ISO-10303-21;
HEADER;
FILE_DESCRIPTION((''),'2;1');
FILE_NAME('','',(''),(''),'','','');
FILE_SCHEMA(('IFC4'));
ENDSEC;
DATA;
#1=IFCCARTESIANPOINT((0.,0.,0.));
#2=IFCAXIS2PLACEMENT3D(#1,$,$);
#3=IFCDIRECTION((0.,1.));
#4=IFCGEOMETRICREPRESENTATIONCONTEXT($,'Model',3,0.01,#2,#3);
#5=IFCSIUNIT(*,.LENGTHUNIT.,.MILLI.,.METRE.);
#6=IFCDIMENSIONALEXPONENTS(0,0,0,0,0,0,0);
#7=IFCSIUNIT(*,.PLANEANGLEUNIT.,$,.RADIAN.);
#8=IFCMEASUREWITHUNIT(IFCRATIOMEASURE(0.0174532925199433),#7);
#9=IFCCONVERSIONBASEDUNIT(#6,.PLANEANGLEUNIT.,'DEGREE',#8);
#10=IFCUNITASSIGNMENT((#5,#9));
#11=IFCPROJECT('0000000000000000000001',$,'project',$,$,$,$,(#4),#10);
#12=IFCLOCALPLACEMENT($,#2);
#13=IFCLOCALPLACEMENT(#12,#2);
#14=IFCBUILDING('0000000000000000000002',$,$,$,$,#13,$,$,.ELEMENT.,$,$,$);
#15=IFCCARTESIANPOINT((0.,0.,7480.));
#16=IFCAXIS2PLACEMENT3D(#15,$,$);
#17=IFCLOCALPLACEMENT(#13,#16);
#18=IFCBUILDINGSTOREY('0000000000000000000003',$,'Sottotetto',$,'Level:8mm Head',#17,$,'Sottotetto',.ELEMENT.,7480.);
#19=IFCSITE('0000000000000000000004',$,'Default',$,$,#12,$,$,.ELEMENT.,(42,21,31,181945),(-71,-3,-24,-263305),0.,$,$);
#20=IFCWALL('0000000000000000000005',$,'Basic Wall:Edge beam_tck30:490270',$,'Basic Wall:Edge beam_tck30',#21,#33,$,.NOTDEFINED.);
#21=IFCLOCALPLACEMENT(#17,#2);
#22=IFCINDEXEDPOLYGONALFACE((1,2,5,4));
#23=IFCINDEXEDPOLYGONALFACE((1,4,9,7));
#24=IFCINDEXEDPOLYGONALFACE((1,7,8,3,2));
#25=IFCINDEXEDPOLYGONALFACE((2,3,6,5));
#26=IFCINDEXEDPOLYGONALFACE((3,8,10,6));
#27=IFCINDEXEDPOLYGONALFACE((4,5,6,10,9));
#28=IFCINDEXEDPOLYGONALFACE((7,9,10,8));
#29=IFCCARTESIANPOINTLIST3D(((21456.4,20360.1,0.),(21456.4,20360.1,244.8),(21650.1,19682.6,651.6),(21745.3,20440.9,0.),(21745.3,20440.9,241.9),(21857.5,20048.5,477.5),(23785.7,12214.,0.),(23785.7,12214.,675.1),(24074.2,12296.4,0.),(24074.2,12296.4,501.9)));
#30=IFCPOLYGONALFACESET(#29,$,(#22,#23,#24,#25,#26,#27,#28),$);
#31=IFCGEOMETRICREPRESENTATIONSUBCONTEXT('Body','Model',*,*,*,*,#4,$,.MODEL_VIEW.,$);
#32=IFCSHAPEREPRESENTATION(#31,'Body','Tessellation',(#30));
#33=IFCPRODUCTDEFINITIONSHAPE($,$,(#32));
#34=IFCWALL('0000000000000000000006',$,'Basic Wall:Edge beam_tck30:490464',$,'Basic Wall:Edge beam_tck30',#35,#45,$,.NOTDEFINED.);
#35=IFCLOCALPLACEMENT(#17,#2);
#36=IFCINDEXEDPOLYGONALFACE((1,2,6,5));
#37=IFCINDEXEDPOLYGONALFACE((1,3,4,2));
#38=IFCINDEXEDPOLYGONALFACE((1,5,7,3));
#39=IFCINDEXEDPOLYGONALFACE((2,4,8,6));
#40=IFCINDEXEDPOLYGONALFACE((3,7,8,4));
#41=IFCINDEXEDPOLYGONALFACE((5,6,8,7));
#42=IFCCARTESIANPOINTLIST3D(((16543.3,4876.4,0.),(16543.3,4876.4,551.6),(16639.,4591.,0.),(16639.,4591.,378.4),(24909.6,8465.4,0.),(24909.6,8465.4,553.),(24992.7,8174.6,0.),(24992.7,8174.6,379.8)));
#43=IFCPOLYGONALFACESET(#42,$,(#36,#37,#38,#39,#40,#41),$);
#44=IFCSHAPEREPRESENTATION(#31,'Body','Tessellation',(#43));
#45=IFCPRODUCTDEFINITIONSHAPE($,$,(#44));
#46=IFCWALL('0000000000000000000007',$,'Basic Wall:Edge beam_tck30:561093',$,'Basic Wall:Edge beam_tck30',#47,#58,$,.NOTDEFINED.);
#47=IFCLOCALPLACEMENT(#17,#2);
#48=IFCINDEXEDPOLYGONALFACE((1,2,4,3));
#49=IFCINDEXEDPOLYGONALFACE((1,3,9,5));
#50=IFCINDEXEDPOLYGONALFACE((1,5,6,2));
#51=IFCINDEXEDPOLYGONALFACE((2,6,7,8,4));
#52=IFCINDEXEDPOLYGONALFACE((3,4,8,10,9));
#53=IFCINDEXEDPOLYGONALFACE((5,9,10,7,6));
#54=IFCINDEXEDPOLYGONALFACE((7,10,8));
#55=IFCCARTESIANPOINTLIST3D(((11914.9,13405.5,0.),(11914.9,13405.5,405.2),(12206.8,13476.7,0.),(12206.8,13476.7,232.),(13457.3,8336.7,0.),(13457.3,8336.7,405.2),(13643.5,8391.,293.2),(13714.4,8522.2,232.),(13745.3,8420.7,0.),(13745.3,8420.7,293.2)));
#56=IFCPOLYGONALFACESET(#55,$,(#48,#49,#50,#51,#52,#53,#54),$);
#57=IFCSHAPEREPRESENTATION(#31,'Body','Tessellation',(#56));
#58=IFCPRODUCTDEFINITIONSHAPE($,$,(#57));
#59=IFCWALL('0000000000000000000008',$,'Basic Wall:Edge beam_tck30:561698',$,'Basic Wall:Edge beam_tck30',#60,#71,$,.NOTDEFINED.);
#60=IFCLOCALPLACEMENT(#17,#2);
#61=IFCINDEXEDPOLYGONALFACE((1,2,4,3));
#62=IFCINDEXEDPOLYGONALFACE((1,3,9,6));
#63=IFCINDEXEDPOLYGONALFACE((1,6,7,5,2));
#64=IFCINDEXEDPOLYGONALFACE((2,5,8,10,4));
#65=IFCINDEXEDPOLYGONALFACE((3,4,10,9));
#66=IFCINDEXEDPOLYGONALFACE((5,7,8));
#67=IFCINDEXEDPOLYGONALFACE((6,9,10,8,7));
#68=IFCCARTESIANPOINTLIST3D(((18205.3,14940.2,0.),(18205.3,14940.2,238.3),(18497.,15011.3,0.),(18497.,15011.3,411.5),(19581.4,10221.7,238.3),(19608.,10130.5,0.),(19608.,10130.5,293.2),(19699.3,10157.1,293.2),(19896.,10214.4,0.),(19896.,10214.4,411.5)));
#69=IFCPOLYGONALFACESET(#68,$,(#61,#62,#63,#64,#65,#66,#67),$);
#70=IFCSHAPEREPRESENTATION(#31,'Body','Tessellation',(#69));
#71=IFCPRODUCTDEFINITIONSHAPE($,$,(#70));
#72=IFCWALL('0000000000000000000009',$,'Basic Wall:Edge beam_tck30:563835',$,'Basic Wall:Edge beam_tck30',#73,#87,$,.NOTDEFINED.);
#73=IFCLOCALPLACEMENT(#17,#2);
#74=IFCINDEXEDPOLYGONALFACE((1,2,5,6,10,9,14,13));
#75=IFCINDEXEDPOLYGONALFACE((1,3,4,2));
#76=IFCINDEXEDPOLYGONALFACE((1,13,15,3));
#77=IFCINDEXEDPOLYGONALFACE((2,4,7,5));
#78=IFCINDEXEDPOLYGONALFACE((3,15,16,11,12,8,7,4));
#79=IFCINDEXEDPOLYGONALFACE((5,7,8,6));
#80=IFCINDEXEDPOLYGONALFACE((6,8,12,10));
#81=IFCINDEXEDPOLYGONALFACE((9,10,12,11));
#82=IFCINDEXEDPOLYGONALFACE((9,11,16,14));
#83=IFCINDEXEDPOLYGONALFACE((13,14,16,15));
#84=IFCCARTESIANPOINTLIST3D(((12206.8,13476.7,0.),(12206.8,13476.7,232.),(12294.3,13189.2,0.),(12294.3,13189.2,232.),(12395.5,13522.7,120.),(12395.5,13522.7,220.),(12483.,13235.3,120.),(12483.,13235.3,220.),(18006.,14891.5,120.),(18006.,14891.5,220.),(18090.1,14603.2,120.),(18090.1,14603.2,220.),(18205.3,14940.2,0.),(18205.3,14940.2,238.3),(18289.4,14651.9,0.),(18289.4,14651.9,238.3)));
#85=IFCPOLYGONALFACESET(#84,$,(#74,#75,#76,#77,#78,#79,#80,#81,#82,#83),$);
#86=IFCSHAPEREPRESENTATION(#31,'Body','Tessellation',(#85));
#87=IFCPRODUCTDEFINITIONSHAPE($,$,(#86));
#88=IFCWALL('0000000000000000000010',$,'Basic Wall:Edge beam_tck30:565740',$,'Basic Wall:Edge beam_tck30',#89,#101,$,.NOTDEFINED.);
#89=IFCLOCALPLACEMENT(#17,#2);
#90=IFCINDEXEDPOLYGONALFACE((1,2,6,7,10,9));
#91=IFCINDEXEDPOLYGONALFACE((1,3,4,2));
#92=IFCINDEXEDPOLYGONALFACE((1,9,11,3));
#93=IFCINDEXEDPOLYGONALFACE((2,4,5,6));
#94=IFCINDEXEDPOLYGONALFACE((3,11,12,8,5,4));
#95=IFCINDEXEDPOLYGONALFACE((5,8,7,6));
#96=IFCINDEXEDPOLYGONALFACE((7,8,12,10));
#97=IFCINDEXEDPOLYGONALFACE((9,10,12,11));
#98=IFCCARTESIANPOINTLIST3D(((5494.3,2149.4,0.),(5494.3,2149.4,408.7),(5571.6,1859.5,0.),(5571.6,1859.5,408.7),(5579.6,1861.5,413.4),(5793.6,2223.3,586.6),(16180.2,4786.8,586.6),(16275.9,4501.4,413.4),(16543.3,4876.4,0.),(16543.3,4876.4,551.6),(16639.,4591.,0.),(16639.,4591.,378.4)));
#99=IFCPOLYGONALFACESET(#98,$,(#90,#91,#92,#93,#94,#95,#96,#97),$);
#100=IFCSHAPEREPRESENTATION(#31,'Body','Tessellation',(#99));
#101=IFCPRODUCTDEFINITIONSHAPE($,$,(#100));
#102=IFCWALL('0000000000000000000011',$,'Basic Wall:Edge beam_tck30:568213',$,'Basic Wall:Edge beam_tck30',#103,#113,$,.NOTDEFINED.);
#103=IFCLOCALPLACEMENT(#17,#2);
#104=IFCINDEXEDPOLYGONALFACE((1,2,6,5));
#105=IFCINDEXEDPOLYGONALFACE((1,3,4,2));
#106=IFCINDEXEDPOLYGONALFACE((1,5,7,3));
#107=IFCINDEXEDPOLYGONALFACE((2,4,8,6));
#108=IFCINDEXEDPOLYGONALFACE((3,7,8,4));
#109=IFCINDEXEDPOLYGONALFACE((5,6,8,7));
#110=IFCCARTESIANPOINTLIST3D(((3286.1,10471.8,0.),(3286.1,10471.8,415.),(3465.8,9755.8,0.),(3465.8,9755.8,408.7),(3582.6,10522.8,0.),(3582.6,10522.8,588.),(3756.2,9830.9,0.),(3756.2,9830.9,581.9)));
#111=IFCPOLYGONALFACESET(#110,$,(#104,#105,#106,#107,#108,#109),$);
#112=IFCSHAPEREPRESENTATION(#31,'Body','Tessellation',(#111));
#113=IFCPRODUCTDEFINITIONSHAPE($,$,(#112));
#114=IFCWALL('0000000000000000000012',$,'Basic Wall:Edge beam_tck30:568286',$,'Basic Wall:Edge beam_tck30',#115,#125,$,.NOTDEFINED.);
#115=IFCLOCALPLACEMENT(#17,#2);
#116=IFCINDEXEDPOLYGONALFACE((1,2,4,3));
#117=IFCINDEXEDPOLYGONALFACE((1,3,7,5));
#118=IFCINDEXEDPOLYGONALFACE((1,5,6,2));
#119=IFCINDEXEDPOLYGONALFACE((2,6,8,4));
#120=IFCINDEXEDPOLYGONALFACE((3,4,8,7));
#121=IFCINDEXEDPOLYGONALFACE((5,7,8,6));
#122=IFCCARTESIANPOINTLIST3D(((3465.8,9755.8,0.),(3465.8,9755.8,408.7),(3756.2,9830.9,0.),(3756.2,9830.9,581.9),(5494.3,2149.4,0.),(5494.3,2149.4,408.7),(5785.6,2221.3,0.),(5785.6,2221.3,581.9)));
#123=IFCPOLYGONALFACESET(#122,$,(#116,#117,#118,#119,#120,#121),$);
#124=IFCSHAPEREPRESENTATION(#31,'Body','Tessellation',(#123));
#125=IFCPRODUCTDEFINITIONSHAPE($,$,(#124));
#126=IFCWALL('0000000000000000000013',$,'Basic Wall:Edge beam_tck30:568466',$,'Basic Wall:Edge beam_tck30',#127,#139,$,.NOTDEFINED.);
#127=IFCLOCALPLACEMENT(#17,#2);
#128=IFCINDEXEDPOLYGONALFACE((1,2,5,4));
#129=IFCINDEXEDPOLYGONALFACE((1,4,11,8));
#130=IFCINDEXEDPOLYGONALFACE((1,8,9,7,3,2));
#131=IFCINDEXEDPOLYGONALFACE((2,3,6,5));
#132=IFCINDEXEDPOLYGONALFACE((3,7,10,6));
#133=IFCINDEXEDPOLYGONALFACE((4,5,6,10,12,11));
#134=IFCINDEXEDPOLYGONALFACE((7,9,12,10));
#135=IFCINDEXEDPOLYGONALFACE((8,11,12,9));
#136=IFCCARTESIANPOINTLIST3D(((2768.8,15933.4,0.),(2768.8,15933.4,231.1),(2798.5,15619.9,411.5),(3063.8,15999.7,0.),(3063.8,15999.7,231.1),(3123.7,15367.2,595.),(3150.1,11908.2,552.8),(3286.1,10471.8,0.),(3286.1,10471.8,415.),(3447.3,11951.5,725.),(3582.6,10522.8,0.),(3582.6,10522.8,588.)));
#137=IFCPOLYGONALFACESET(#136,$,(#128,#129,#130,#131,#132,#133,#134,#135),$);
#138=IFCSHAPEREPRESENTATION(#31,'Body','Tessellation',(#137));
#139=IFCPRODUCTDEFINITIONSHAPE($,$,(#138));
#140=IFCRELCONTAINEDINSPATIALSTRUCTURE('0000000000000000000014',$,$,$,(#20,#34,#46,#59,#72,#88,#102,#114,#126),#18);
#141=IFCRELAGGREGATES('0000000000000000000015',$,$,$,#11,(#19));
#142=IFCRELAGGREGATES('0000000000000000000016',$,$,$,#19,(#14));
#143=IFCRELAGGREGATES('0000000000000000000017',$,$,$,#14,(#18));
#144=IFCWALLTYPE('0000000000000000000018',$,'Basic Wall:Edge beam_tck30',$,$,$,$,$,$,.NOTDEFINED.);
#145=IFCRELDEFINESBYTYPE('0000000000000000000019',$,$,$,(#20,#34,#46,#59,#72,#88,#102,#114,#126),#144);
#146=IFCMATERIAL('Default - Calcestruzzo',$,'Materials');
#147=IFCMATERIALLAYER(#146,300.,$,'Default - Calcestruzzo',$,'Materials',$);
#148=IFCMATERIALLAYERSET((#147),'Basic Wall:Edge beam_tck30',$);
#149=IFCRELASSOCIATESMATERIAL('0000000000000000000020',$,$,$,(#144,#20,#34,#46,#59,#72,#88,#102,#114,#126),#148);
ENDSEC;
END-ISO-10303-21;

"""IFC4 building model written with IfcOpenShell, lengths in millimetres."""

from ifc_helpers import new_model, entity, si_unit, converted_unit, direction, frame, origin, place, context, subcontext, project, spatial, polyline, outline, extrude, clip, bounded_halfspace, material, layer, layer_set, layer_usage, type_object, element, save


model = new_model("IFC4")

# Units and contexts
model_context = context("Model", 3, precision=0.01, world=origin(), true_north=direction((0.0, 1.0)))
body_context = subcontext(model_context, "Body", "Model", "MODEL_VIEW")
ifc_project = project(units=[si_unit("LENGTHUNIT", "METRE", prefix="MILLI"), converted_unit("PLANEANGLEUNIT", "DEGREE", entity("IfcRatioMeasure", 0.0174532925199433), si_unit("PLANEANGLEUNIT", "RADIAN"), dimensions=[0, 0, 0, 0, 0, 0, 0])], contexts=[model_context])

# Site, building, storey
site_placement = place(None, origin())
site = spatial("IfcSite", under=ifc_project, at=site_placement, Name="Default", CompositionType="ELEMENT", RefLatitude=(42, 21, 31, 181945), RefLongitude=(-71, -3, -24, -263305), RefElevation=0.0)
building_placement = place(site_placement, origin())
building = spatial("IfcBuilding", under=site, at=building_placement, CompositionType="ELEMENT")
storey_placement = place(building_placement, frame((0.0, 0.0, 7480.0)))
storey = spatial("IfcBuildingStorey", under=building, at=storey_placement, Name="Sottotetto", ObjectType="Level:8mm Head", LongName="Sottotetto", CompositionType="ELEMENT", Elevation=7480.0)

# Walls
ifc_material_1 = material(Name="Default - Calcestruzzo", Category="Materials")
ifc_layer_1 = layer(ifc_material_1, 300.0, Name="Default - Calcestruzzo", Category="Materials")
ifc_layer_set_1 = layer_set([ifc_layer_1], Name="Basic Wall:Edge beam_tck30")
ifc_layer_usage_1 = layer_usage(ifc_layer_set_1, "AXIS2", "NEGATIVE", 150.0)
wall_type = type_object("IfcWallType", Name="Basic Wall:Edge beam_tck30", PredefinedType="NOTDEFINED", material=ifc_layer_set_1)
wall_1_placement = place(storey_placement, frame((21600.6, 20401.4, 0.0), z_axis=(0.0, 0.0, 1.0), x_axis=(0.274927, -0.961465, 0.0)))
element("IfcWall", 1, at=wall_1_placement, inside=storey, type_object=wall_type, material=ifc_layer_usage_1, Name="Basic Wall:Edge beam_tck30:490270", ObjectType="Basic Wall:Edge beam_tck30", PredefinedType="NOTDEFINED", context=body_context, shape_type="Clipping", body=[
    clip(clip(extrude(outline(polyline([(8472.6, -150.0), (8472.6, -100.1), (8472.6, 150.0), (1.8, 150.0), (0.0, -150.0), (300.0, -150.0), (8472.6, -150.0)])), origin(), (0.0, 0.0, 1.0), 675.1), bounded_halfspace(frame((0.0, -150.0, 244.8), z_axis=(-0.499867, 0.011539, 0.866025), x_axis=(-0.023077, -0.999734, 0.0)), False, frame((0.0, -150.0, 244.8)), polyline([(0.0, 0.0), (704.6, 0.0), (409.9, 300.0), (1.8, 300.0), (0.0, 0.0)]))), bounded_halfspace(frame((704.6, -150.0, 651.6), z_axis=(-0.002627, 0.499993, 0.866025), x_axis=(-0.999986, -0.005253, 0.0)), False, frame((704.6, -150.0, 651.6)), polyline([(0.0, 0.0), (7768.0, 0.0), (7768.0, 49.9), (7768.0, 300.0), (-294.7, 300.0), (0.0, 0.0)]))),
])
ifc_layer_usage_2 = layer_usage(ifc_layer_set_1, "AXIS2", "NEGATIVE", 150.0)
wall_2_placement = place(storey_placement, frame((24968.7, 8327.5, 0.0), z_axis=(0.0, 0.0, 1.0), x_axis=(-0.919009, -0.394236, 0.0)))
element("IfcWall", 2, at=wall_2_placement, inside=storey, type_object=wall_type, material=ifc_layer_usage_2, Name="Basic Wall:Edge beam_tck30:490464", ObjectType="Basic Wall:Edge beam_tck30", PredefinedType="NOTDEFINED", context=body_context, shape_type="Clipping", body=[
    clip(extrude(outline(polyline([(9103.6, -150.0), (9128.2, 150.0), (38.2, 150.0), (0.0, -150.0), (9103.6, -150.0)])), origin(), (0.0, 0.0, 1.0), 553.0), bounded_halfspace(frame((0.0, -150.0, 553.0), z_axis=(0.000133, 0.5, 0.866025), x_axis=(-1.0, 0.000267, 0.0)), False, frame((0.0, -150.0, 553.0)), polyline([(0.0, 0.0), (9103.6, 0.0), (9128.2, 300.0), (38.2, 300.0), (0.0, 0.0)]))),
])
ifc_layer_usage_3 = layer_usage(ifc_layer_set_1, "AXIS2", "NEGATIVE", 150.0)
wall_3_placement = place(storey_placement, frame((13601.8, 8377.0, 0.0), z_axis=(0.0, 0.0, 1.0), x_axis=(-0.291111, 0.956689, 0.0)))
element("IfcWall", 3, at=wall_3_placement, inside=storey, type_object=wall_type, material=ifc_layer_usage_3, Name="Basic Wall:Edge beam_tck30:561093", ObjectType="Basic Wall:Edge beam_tck30", PredefinedType="NOTDEFINED", context=body_context, shape_type="Clipping", body=[
    clip(clip(extrude(outline(polyline([(5284.9, -150.0), (5301.7, 150.0), (3.5, 150.0), (0.0, -150.0), (300.0, -150.0), (4984.4, -150.0), (5284.9, -150.0)])), origin(), (0.0, 0.0, 1.0), 405.2), bounded_halfspace(frame((106.1, -150.0, 232.0), z_axis=(0.0, -0.5, 0.866025), x_axis=(1.0, 0.0, 0.0)), False, frame((106.1, -150.0, 232.0)), polyline([(0.0, 0.0), (193.9, 0.0), (4878.3, 0.0), (5178.8, 0.0), (5195.7, 300.0), (-102.6, 300.0), (-104.8, 106.1), (0.0, 0.0)]))), bounded_halfspace(frame((0.0, -150.0, 293.2), z_axis=(0.499966, -0.00581, 0.866025), x_axis=(0.01162, 0.999932, 0.0)), False, frame((0.0, -150.0, 293.2)), polyline([(0.0, 0.0), (106.1, 0.0), (1.2, 106.1), (0.0, 0.0)]))),
])
ifc_layer_usage_4 = layer_usage(ifc_layer_set_1, "AXIS2", "NEGATIVE", 150.0)
wall_4_placement = place(storey_placement, frame((18349.3, 14982.1, 0.0), z_axis=(0.0, 0.0, 1.0), x_axis=(0.279974, -0.960008, 0.0)))
element("IfcWall", 4, at=wall_4_placement, inside=storey, type_object=wall_type, material=ifc_layer_usage_4, Name="Basic Wall:Edge beam_tck30:561698", ObjectType="Basic Wall:Edge beam_tck30", PredefinedType="NOTDEFINED", context=body_context, shape_type="Clipping", body=[
    clip(clip(extrude(outline(polyline([(5010.1, -150.0), (5010.1, 150.0), (13.3, 150.0), (0.0, -150.0), (300.3, -150.0), (4710.1, -150.0), (5010.1, -150.0)])), origin(), (0.0, 0.0, 1.0), 411.5), bounded_halfspace(frame((0.0, -150.0, 238.3), z_axis=(0.0, -0.5, 0.866025), x_axis=(1.0, 0.0, 0.0)), False, frame((0.0, -150.0, 238.3)), polyline([(0.0, 0.0), (300.3, 0.0), (4710.1, 0.0), (4915.0, 0.0), (5010.1, 95.1), (5010.1, 300.0), (13.3, 300.0), (0.0, 0.0)]))), bounded_halfspace(frame((4915.0, -150.0, 238.3), z_axis=(-0.5, 0.0, 0.866025), x_axis=(0.0, -1.0, 0.0)), False, frame((4915.0, -150.0, 238.3)), polyline([(0.0, 0.0), (95.1, 0.0), (95.1, 95.1), (0.0, 0.0)]))),
])
ifc_layer_usage_5 = layer_usage(ifc_layer_set_1, "AXIS2", "NEGATIVE", 150.0)
wall_5_placement = place(storey_placement, frame((12242.4, 13330.9, 0.0), z_axis=(0.0, 0.0, 1.0), x_axis=(0.971504, 0.237022, 0.0)))
element("IfcWall", 5, at=wall_5_placement, inside=storey, type_object=wall_type, material=ifc_layer_usage_5, Name="Basic Wall:Edge beam_tck30:563835", ObjectType="Basic Wall:Edge beam_tck30", PredefinedType="NOTDEFINED", context=body_context, shape_type="Clipping", body=[
    clip(clip(clip(extrude(outline(polyline([(6187.8, -150.0), (6174.4, 150.0), (0.0, 150.0), (16.8, -150.0), (6187.8, -150.0)])), origin(), (0.0, 0.0, 1.0), 238.3), bounded_halfspace(frame((16.8, -150.0, 232.0), z_axis=(0.499214, 0.02803, 0.866025), x_axis=(-0.056059, 0.998427, 0.0)), False, frame((16.8, -150.0, 232.0)), polyline([(0.0, 0.0), (194.2, 0.0), (177.4, 300.0), (-16.8, 300.0), (0.0, 0.0)]))), bounded_halfspace(frame((5982.7, -150.0, 120.0), z_axis=(-0.499506, -0.022227, 0.866025), x_axis=(0.044453, -0.999011, 0.0)), False, frame((5982.7, -150.0, 120.0)), polyline([(0.0, 0.0), (205.1, 0.0), (191.8, 300.0), (-13.3, 300.0), (0.0, 0.0)]))), bounded_halfspace(frame((211.1, -150.0, 220.0), z_axis=(0.0, 0.0, 1.0), x_axis=(0.0, 1.0, 0.0)), False, frame((211.1, -150.0, 220.0)), polyline([(0.0, 0.0), (5771.6, 0.0), (5758.2, 300.0), (-16.8, 300.0), (0.0, 0.0)]))),
])
ifc_layer_usage_6 = layer_usage(ifc_layer_set_1, "AXIS2", "NEGATIVE", 150.0)
wall_6_placement = place(storey_placement, frame((5530.2, 2003.8, 0.0), z_axis=(0.0, 0.0, 1.0), x_axis=(0.970868, 0.239617, 0.0)))
element("IfcWall", 6, at=wall_6_placement, inside=storey, type_object=wall_type, material=ifc_layer_usage_6, Name="Basic Wall:Edge beam_tck30:565740", ObjectType="Basic Wall:Edge beam_tck30", PredefinedType="NOTDEFINED", context=body_context, shape_type="Clipping", body=[
    clip(clip(clip(extrude(outline(polyline([(11405.1, -150.0), (11380.5, 150.0), (300.1, 150.0), (0.0, 150.0), (5.6, -150.0), (11405.1, -150.0)])), origin(), (0.0, 0.0, 1.0), 586.6), bounded_halfspace(frame((11031.1, -150.0, 413.4), z_axis=(0.081139, -0.493373, 0.866025), x_axis=(0.986745, 0.162278, 0.0)), False, frame((11031.1, -150.0, 413.4)), polyline([(0.0, 0.0), (374.0, 0.0), (349.4, 300.0), (-24.5, 300.0), (0.0, 0.0)]))), bounded_halfspace(frame((13.9, -150.0, 413.4), z_axis=(0.0, -0.5, 0.866025), x_axis=(1.0, 0.0, 0.0)), False, frame((13.9, -150.0, 413.4)), polyline([(0.0, 0.0), (11017.2, 0.0), (10992.7, 300.0), (294.5, 300.0), (0.0, 0.0)]))), bounded_halfspace(frame((5.6, -150.0, 408.7), z_axis=(-0.499913, -0.009326, 0.866025), x_axis=(0.018652, -0.999826, 0.0)), False, frame((5.6, -150.0, 408.7)), polyline([(0.0, 0.0), (8.3, 0.0), (302.7, 300.0), (294.5, 300.0), (-5.6, 300.0), (0.0, 0.0)]))),
])
ifc_layer_usage_7 = layer_usage(ifc_layer_set_1, "AXIS2", "NEGATIVE", 150.0)
wall_7_placement = place(storey_placement, frame((3431.6, 10508.3, 0.0), z_axis=(0.0, 0.0, 1.0), x_axis=(0.243349, -0.969939, 0.0)))
element("IfcWall", 7, at=wall_7_placement, inside=storey, type_object=wall_type, material=ifc_layer_usage_7, Name="Basic Wall:Edge beam_tck30:568213", ObjectType="Basic Wall:Edge beam_tck30", PredefinedType="NOTDEFINED", context=body_context, shape_type="Clipping", body=[
    clip(extrude(outline(polyline([(738.3, -150.0), (736.0, 150.0), (22.7, 150.0), (0.0, -150.0), (738.3, -150.0)])), origin(), (0.0, 0.0, 1.0), 588.0), bounded_halfspace(frame((0.0, -150.0, 415.0), z_axis=(0.007403, -0.499945, 0.866025), x_axis=(0.99989, 0.014806, 0.0)), False, frame((0.0, -150.0, 415.0)), polyline([(0.0, 0.0), (738.3, 0.0), (736.0, 300.0), (22.7, 300.0), (0.0, 0.0)]))),
])
ifc_layer_usage_8 = layer_usage(ifc_layer_set_1, "AXIS2", "NEGATIVE", 150.0)
wall_8_placement = place(storey_placement, frame((3610.7, 9794.4, 0.0), z_axis=(0.0, 0.0, 1.0), x_axis=(0.257683, -0.966229, 0.0)))
element("IfcWall", 8, at=wall_8_placement, inside=storey, type_object=wall_type, material=ifc_layer_usage_8, Name="Basic Wall:Edge beam_tck30:568286", ObjectType="Basic Wall:Edge beam_tck30", PredefinedType="NOTDEFINED", context=body_context, shape_type="Clipping", body=[
    clip(extrude(outline(polyline([(7872.2, -150.0), (7877.8, 150.0), (2.2, 150.0), (0.0, -150.0), (7872.2, -150.0)])), origin(), (0.0, 0.0, 1.0), 581.9), bounded_halfspace(frame((0.0, -150.0, 408.7), z_axis=(0.0, -0.5, 0.866025), x_axis=(1.0, 0.0, 0.0)), False, frame((0.0, -150.0, 408.7)), polyline([(0.0, 0.0), (7872.2, 0.0), (7877.8, 300.0), (2.2, 300.0), (0.0, 0.0)]))),
])
ifc_layer_usage_9 = layer_usage(ifc_layer_set_1, "AXIS2", "NEGATIVE", 150.0)
wall_9_placement = place(storey_placement, frame((3435.4, 10486.0, 0.0), z_axis=(0.0, 0.0, 1.0), x_axis=(-0.094302, 0.995544, 0.0)))
element("IfcWall", 9, at=wall_9_placement, inside=storey, type_object=wall_type, material=ifc_layer_usage_9, Name="Basic Wall:Edge beam_tck30:568466", ObjectType="Basic Wall:Edge beam_tck30", PredefinedType="NOTDEFINED", context=body_context, shape_type="Clipping", body=[
    clip(clip(clip(extrude(outline(polyline([(5524.2, -150.0), (5486.0, 150.0), (0.0, 150.0), (22.7, -150.0), (5221.8, -150.0), (5524.2, -150.0)])), origin(), (0.0, 0.0, 1.0), 725.0), bounded_halfspace(frame((22.7, -150.0, 588.0), z_axis=(-0.082709, 0.493112, 0.866025), x_axis=(-0.986224, -0.165417, 0.0)), False, frame((22.7, -150.0, 588.0)), polyline([(0.0, 0.0), (1435.2, 0.0), (1420.1, 300.0), (-22.7, 300.0), (0.0, 0.0)]))), bounded_halfspace(frame((1457.9, -150.0, 725.0), z_axis=(0.032826, 0.498921, 0.866025), x_axis=(-0.997843, 0.065652, 0.0)), False, frame((1457.9, -150.0, 725.0)), polyline([(0.0, 0.0), (3430.9, 0.0), (3713.2, 300.0), (-15.1, 300.0), (0.0, 0.0)]))), bounded_halfspace(frame((4888.9, -150.0, 595.0), z_axis=(0.496005, 0.06308, 0.866025), x_axis=(-0.12616, 0.99201, 0.0)), False, frame((4888.9, -150.0, 595.0)), polyline([(0.0, 0.0), (635.4, 0.0), (597.1, 300.0), (282.3, 300.0), (0.0, 0.0)]))),
])

save(model, "model.ifc")
